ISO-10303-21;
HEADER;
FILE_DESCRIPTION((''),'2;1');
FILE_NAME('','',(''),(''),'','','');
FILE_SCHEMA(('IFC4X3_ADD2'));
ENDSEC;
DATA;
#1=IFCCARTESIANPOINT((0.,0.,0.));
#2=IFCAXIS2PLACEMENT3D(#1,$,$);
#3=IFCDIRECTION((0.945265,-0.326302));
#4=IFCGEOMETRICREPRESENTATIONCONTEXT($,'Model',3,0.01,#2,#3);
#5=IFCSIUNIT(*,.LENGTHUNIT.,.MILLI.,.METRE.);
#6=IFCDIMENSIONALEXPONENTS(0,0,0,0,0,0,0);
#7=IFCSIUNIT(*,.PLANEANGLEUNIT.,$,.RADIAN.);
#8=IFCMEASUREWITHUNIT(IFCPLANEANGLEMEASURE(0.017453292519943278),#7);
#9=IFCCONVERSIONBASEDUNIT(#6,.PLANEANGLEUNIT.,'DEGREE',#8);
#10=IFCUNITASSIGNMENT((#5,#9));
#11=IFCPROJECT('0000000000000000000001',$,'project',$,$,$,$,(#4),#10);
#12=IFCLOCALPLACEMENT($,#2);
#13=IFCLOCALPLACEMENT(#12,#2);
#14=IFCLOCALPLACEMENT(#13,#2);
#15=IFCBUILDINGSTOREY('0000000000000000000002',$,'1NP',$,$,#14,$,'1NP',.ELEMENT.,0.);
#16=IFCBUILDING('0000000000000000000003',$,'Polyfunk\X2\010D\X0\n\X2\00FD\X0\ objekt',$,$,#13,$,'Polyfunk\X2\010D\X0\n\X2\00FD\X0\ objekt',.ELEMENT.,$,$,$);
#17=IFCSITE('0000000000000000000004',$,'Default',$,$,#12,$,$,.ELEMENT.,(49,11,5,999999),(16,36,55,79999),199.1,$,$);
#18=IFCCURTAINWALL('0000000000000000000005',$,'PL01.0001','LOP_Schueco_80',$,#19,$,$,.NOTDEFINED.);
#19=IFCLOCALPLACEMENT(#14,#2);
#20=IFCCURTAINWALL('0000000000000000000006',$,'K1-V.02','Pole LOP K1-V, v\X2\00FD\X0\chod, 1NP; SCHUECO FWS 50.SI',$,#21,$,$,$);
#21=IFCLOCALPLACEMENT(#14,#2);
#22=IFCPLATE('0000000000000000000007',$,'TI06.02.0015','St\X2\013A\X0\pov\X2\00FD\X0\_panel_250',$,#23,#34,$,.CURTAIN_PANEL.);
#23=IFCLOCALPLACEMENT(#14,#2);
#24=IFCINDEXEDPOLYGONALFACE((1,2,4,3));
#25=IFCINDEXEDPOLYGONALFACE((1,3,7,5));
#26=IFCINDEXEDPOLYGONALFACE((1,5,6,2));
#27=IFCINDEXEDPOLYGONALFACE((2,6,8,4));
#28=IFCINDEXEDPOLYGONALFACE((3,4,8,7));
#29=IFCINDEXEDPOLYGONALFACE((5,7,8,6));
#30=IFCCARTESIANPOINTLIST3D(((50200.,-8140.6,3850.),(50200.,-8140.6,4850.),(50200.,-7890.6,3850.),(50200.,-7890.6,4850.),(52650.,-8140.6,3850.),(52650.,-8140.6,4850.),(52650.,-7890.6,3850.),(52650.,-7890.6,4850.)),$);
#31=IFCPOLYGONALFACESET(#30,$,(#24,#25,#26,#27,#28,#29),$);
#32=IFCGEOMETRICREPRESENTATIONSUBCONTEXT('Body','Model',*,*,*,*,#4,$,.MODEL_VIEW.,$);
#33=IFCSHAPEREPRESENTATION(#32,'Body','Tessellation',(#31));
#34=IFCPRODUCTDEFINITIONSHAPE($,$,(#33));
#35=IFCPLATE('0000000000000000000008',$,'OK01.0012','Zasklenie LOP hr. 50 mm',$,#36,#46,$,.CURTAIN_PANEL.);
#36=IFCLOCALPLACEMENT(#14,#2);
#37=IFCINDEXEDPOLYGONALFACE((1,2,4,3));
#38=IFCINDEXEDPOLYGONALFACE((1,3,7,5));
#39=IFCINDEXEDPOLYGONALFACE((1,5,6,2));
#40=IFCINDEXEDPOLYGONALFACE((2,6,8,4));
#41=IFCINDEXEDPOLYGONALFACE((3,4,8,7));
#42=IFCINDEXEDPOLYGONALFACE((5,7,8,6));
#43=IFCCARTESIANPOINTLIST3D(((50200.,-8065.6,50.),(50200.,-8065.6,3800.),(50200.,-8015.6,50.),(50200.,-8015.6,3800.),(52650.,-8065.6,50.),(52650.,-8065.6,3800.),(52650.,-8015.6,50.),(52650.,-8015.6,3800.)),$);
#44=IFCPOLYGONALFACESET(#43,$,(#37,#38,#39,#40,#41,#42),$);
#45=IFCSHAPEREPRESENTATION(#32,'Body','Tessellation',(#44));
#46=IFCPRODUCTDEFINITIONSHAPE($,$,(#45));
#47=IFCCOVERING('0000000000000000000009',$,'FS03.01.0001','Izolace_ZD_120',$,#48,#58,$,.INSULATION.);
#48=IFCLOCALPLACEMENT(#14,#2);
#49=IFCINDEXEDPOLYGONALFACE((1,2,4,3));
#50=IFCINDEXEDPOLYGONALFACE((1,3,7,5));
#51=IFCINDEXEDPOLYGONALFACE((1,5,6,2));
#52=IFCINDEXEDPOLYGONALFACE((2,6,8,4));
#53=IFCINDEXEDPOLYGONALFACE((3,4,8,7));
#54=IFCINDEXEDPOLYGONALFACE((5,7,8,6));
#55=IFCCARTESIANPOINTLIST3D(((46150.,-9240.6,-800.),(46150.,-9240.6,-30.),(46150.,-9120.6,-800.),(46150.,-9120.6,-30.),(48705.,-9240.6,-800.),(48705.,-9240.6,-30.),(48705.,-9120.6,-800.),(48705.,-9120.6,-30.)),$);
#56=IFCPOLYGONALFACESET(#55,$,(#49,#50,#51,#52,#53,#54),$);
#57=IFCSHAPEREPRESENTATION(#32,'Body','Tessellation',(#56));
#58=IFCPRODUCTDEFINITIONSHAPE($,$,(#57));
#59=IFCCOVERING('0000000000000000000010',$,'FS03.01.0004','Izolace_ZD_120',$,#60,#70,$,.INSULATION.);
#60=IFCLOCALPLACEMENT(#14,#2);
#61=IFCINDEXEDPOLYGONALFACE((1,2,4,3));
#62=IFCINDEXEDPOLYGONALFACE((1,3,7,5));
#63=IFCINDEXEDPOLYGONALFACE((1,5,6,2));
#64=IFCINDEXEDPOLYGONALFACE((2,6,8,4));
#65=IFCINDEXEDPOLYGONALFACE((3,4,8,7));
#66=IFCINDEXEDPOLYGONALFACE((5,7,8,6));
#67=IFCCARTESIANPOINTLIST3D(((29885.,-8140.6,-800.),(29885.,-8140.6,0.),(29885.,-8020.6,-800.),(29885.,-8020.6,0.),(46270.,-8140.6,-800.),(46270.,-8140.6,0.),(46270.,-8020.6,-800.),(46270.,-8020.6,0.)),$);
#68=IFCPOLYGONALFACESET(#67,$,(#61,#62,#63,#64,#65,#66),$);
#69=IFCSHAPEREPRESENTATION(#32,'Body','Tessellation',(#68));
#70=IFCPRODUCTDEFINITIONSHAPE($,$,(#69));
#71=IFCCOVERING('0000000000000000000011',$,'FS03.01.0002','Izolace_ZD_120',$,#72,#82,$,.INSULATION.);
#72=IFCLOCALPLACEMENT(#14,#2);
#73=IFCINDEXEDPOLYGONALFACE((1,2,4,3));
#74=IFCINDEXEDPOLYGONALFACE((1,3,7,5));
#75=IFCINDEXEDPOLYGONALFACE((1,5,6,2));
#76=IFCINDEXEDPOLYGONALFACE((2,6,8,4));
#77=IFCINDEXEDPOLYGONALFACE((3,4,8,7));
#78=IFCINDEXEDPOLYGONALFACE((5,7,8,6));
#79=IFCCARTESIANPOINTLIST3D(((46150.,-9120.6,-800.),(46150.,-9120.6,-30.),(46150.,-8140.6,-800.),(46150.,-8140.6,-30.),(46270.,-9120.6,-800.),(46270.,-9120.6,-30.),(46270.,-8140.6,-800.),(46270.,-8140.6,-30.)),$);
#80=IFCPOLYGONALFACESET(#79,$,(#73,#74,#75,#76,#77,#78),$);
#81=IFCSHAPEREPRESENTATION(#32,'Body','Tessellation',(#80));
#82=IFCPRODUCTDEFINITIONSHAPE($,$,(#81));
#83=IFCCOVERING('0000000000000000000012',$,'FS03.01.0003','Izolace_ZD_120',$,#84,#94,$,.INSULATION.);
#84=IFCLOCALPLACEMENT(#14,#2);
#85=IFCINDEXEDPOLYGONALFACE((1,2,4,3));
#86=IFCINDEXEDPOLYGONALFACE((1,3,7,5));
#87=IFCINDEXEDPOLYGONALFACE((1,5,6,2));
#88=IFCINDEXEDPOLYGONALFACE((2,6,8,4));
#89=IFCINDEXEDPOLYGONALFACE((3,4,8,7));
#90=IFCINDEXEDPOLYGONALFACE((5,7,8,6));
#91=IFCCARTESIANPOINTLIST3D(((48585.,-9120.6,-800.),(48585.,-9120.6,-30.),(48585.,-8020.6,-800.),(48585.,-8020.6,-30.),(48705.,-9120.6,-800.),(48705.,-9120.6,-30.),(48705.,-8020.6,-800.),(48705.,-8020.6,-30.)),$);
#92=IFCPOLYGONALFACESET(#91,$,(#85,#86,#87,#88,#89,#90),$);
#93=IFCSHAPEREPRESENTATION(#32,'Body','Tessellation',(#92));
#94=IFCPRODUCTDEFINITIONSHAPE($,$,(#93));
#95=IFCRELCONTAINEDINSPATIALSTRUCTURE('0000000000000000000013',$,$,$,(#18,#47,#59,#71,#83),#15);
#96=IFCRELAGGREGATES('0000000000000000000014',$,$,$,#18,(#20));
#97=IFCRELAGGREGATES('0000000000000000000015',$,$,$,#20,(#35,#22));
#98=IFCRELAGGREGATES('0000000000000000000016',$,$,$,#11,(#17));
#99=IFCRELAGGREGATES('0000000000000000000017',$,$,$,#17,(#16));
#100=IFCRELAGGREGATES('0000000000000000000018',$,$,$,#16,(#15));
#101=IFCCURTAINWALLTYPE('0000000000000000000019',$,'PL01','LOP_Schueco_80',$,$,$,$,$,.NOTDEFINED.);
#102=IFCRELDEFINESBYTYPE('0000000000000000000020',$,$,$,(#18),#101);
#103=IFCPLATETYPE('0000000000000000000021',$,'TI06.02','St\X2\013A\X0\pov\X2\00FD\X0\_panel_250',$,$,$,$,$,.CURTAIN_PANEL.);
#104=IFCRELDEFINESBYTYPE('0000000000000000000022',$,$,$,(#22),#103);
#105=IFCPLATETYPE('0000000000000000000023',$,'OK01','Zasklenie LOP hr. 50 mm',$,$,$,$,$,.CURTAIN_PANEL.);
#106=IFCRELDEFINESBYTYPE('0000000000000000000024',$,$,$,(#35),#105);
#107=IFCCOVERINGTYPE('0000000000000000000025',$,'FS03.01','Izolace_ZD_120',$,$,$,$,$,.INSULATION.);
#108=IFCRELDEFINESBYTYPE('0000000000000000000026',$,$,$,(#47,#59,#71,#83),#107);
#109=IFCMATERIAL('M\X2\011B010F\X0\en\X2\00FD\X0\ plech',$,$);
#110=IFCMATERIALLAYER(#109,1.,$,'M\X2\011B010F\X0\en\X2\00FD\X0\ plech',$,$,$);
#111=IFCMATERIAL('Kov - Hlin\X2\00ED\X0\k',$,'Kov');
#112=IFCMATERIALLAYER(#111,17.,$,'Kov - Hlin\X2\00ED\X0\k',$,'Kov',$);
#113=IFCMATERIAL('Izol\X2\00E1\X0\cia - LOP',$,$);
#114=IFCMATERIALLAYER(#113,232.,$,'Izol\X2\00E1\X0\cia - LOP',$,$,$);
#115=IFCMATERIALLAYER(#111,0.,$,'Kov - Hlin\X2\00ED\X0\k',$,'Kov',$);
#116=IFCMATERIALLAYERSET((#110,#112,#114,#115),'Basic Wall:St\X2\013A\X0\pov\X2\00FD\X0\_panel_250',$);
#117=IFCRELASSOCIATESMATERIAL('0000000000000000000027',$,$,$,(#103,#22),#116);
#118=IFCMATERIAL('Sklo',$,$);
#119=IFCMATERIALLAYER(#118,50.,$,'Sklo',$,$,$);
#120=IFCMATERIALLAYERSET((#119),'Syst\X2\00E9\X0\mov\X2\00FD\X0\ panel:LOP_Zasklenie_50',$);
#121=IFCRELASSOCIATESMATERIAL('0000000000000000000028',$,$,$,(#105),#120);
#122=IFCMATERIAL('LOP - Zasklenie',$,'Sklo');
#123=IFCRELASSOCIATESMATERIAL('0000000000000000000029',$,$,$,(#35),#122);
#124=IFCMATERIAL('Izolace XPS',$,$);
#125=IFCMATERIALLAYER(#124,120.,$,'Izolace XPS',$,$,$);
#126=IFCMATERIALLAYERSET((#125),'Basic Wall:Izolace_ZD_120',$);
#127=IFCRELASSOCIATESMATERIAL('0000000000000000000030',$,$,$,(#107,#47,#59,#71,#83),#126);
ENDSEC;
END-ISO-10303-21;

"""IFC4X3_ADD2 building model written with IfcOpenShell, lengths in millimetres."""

from ifc_helpers import new_model, entity, si_unit, converted_unit, direction, frame, frame_2d, origin, origin_2d_with_axis, place, context, subcontext, project, spatial, rectangle, extrude, source, transform, mapped, material, layer, layer_set, layer_usage, type_object, type_shapes, element, aggregate, save


model = new_model("IFC4X3_ADD2")

# Units and contexts
model_context = context("Model", 3, precision=0.01, world=origin(), true_north=direction((0.945265, -0.326302)))
body_context = subcontext(model_context, "Body", "Model", "MODEL_VIEW")
ifc_project = project(units=[si_unit("LENGTHUNIT", "METRE", prefix="MILLI"), converted_unit("PLANEANGLEUNIT", "DEGREE", entity("IfcPlaneAngleMeasure", 0.017453292519943278), si_unit("PLANEANGLEUNIT", "RADIAN"), dimensions=[0, 0, 0, 0, 0, 0, 0])], contexts=[model_context])

# Site, building, storey
site_placement = place(None, origin())
site = spatial("IfcSite", under=ifc_project, at=site_placement, Name="Default", CompositionType="ELEMENT", RefLatitude=(49, 11, 5, 999999), RefLongitude=(16, 36, 55, 79999), RefElevation=199.1)
building_placement = place(site_placement, origin())
building = spatial("IfcBuilding", under=site, at=building_placement, Name="Polyfunkčný objekt", LongName="Polyfunkčný objekt", CompositionType="ELEMENT")
storey_placement = place(building_placement, origin())
storey = spatial("IfcBuildingStorey", under=building, at=storey_placement, Name="1NP", LongName="1NP", CompositionType="ELEMENT", Elevation=0.0)

# Curtain walls, plates
curtain_wall_type = type_object("IfcCurtainWallType", Name="PL01", Description="LOP_Schueco_80", PredefinedType="NOTDEFINED")
curtain_wall_1_placement = place(storey_placement, origin())
curtain_wall_1 = element("IfcCurtainWall", 1, at=curtain_wall_1_placement, inside=storey, type_object=curtain_wall_type, Name="PL01.0001", Description="LOP_Schueco_80", PredefinedType="NOTDEFINED")
curtain_wall_2 = element("IfcCurtainWall", 2, Name="K1-V.02", Description="Pole LOP K1-V, východ, 1NP; SCHUECO FWS 50.SI")
aggregate(curtain_wall_1, [curtain_wall_2])
ifc_material_1 = material(Name="Měďený plech")
ifc_layer_1 = layer(ifc_material_1, 1.0, Name="Měďený plech")
ifc_material_2 = material(Name="Kov - Hliník", Category="Kov")
ifc_layer_2 = layer(ifc_material_2, 17.0, Name="Kov - Hliník", Category="Kov")
ifc_material_3 = material(Name="Izolácia - LOP")
ifc_layer_3 = layer(ifc_material_3, 232.0, Name="Izolácia - LOP")
ifc_layer_4 = layer(ifc_material_2, 0.0, Name="Kov - Hliník", Category="Kov")
ifc_layer_set_1 = layer_set([ifc_layer_1, ifc_layer_2, ifc_layer_3, ifc_layer_4], Name="Basic Wall:Stĺpový_panel_250")
ifc_layer_usage = layer_usage(ifc_layer_set_1, "AXIS2", "POSITIVE", -125.0)
plate_type_1 = type_object("IfcPlateType", Name="TI06.02", Description="Stĺpový_panel_250", PredefinedType="CURTAIN_PANEL", material=ifc_layer_set_1)
plate_1_placement = place(storey_placement, frame((50200.0, -8015.6, 3850.0)))
plate_1 = element("IfcPlate", 3, at=plate_1_placement, type_object=plate_type_1, material=ifc_layer_usage, Name="TI06.02.0015", Description="Stĺpový_panel_250", PredefinedType="CURTAIN_PANEL", context=body_context, shape_type="SweptSolid", body=[
    extrude(rectangle(XDim=250.0, YDim=2450.0, at=origin_2d_with_axis()), frame((1225.0, 0.0, 0.0), z_axis=(0.0, 0.0, 1.0), x_axis=(0.0, 1.0, 0.0)), (0.0, 0.0, 1.0), 1000.0),
])
ifc_material_4 = material(Name="LOP - Zasklenie", Category="Sklo")
ifc_material_5 = material(Name="Sklo")
ifc_layer_5 = layer(ifc_material_5, 50.0, Name="Sklo")
ifc_layer_set_2 = layer_set([ifc_layer_5], Name="Systémový panel:LOP_Zasklenie_50")
plate_type_2 = type_object("IfcPlateType", Name="OK01", Description="Zasklenie LOP hr. 50 mm", PredefinedType="CURTAIN_PANEL", material=ifc_layer_set_2)
shared_shape_1 = source(origin(), body_context, "Body", "SweptSolid", [
    extrude(rectangle(XDim=3750.0, YDim=2450.0, at=frame_2d((-331.2, 0.0), x_axis=(1.0, 0.0))), frame((0.0, -50.0, 2206.2), z_axis=(0.0, 1.0, 0.0), x_axis=(0.0, 0.0, 1.0)), (0.0, 0.0, 1.0), 50.0),
])
type_shapes(plate_type_2, [shared_shape_1])
plate_2_placement = place(curtain_wall_1_placement, frame((51425.0, -8015.6, 50.0)))
plate_2 = element("IfcPlate", 4, at=plate_2_placement, type_object=plate_type_2, material=ifc_material_4, Name="OK01.0012", Description="Zasklenie LOP hr. 50 mm", PredefinedType="CURTAIN_PANEL", context=body_context, shape_type="MappedRepresentation", body=[
    mapped(shared_shape_1, transform((0.0, 0.0, 0.0), scale=1.0)),
])
aggregate(curtain_wall_2, [plate_2, plate_1])

# Coverings
ifc_material_6 = material(Name="Izolace XPS")
ifc_layer_6 = layer(ifc_material_6, 120.0, Name="Izolace XPS")
ifc_layer_set_3 = layer_set([ifc_layer_6], Name="Basic Wall:Izolace_ZD_120")
covering_type = type_object("IfcCoveringType", Name="FS03.01", Description="Izolace_ZD_120", PredefinedType="INSULATION", material=ifc_layer_set_3)
covering_1_placement = place(storey_placement, frame((48705.0, -9180.6, -800.0), z_axis=(0.0, 0.0, 1.0), x_axis=(-1.0, 0.0, 0.0)))
element("IfcCovering", 5, at=covering_1_placement, inside=storey, type_object=covering_type, material=ifc_layer_set_3, Name="FS03.01.0001", Description="Izolace_ZD_120", PredefinedType="INSULATION", context=body_context, shape_type="SweptSolid", body=[
    extrude(rectangle(XDim=2555.0, YDim=120.0, at=frame_2d((1277.5, 0.0), x_axis=(-1.0, 0.0))), origin(), (0.0, 0.0, 1.0), 770.0),
])
covering_2_placement = place(storey_placement, frame((46270.0, -8080.6, -800.0), z_axis=(0.0, 0.0, 1.0), x_axis=(-1.0, 0.0, 0.0)))
element("IfcCovering", 6, at=covering_2_placement, inside=storey, type_object=covering_type, material=ifc_layer_set_3, Name="FS03.01.0004", Description="Izolace_ZD_120", PredefinedType="INSULATION", context=body_context, shape_type="SweptSolid", body=[
    extrude(rectangle(XDim=16385.0, YDim=120.0, at=frame_2d((8192.5, 0.0), x_axis=(-1.0, 0.0))), origin(), (0.0, 0.0, 1.0), 800.0),
])
covering_3_placement = place(storey_placement, frame((46210.0, -9120.6, -800.0), z_axis=(0.0, 0.0, 1.0), x_axis=(0.0, 1.0, 0.0)))
element("IfcCovering", 7, at=covering_3_placement, inside=storey, type_object=covering_type, material=ifc_layer_set_3, Name="FS03.01.0002", Description="Izolace_ZD_120", PredefinedType="INSULATION", context=body_context, shape_type="SweptSolid", body=[
    extrude(rectangle(XDim=980.0, YDim=120.0, at=frame_2d((490.0, 0.0), x_axis=(-1.0, 0.0))), origin(), (0.0, 0.0, 1.0), 770.0),
])
covering_4_placement = place(storey_placement, frame((48645.0, -9120.6, -800.0), z_axis=(0.0, 0.0, 1.0), x_axis=(0.0, 1.0, 0.0)))
element("IfcCovering", 8, at=covering_4_placement, inside=storey, type_object=covering_type, material=ifc_layer_set_3, Name="FS03.01.0003", Description="Izolace_ZD_120", PredefinedType="INSULATION", context=body_context, shape_type="SweptSolid", body=[
    extrude(rectangle(XDim=1100.0, YDim=120.0, at=frame_2d((550.0, 0.0), x_axis=(-1.0, 0.0))), origin(), (0.0, 0.0, 1.0), 770.0),
])

save(model, "model.ifc")
